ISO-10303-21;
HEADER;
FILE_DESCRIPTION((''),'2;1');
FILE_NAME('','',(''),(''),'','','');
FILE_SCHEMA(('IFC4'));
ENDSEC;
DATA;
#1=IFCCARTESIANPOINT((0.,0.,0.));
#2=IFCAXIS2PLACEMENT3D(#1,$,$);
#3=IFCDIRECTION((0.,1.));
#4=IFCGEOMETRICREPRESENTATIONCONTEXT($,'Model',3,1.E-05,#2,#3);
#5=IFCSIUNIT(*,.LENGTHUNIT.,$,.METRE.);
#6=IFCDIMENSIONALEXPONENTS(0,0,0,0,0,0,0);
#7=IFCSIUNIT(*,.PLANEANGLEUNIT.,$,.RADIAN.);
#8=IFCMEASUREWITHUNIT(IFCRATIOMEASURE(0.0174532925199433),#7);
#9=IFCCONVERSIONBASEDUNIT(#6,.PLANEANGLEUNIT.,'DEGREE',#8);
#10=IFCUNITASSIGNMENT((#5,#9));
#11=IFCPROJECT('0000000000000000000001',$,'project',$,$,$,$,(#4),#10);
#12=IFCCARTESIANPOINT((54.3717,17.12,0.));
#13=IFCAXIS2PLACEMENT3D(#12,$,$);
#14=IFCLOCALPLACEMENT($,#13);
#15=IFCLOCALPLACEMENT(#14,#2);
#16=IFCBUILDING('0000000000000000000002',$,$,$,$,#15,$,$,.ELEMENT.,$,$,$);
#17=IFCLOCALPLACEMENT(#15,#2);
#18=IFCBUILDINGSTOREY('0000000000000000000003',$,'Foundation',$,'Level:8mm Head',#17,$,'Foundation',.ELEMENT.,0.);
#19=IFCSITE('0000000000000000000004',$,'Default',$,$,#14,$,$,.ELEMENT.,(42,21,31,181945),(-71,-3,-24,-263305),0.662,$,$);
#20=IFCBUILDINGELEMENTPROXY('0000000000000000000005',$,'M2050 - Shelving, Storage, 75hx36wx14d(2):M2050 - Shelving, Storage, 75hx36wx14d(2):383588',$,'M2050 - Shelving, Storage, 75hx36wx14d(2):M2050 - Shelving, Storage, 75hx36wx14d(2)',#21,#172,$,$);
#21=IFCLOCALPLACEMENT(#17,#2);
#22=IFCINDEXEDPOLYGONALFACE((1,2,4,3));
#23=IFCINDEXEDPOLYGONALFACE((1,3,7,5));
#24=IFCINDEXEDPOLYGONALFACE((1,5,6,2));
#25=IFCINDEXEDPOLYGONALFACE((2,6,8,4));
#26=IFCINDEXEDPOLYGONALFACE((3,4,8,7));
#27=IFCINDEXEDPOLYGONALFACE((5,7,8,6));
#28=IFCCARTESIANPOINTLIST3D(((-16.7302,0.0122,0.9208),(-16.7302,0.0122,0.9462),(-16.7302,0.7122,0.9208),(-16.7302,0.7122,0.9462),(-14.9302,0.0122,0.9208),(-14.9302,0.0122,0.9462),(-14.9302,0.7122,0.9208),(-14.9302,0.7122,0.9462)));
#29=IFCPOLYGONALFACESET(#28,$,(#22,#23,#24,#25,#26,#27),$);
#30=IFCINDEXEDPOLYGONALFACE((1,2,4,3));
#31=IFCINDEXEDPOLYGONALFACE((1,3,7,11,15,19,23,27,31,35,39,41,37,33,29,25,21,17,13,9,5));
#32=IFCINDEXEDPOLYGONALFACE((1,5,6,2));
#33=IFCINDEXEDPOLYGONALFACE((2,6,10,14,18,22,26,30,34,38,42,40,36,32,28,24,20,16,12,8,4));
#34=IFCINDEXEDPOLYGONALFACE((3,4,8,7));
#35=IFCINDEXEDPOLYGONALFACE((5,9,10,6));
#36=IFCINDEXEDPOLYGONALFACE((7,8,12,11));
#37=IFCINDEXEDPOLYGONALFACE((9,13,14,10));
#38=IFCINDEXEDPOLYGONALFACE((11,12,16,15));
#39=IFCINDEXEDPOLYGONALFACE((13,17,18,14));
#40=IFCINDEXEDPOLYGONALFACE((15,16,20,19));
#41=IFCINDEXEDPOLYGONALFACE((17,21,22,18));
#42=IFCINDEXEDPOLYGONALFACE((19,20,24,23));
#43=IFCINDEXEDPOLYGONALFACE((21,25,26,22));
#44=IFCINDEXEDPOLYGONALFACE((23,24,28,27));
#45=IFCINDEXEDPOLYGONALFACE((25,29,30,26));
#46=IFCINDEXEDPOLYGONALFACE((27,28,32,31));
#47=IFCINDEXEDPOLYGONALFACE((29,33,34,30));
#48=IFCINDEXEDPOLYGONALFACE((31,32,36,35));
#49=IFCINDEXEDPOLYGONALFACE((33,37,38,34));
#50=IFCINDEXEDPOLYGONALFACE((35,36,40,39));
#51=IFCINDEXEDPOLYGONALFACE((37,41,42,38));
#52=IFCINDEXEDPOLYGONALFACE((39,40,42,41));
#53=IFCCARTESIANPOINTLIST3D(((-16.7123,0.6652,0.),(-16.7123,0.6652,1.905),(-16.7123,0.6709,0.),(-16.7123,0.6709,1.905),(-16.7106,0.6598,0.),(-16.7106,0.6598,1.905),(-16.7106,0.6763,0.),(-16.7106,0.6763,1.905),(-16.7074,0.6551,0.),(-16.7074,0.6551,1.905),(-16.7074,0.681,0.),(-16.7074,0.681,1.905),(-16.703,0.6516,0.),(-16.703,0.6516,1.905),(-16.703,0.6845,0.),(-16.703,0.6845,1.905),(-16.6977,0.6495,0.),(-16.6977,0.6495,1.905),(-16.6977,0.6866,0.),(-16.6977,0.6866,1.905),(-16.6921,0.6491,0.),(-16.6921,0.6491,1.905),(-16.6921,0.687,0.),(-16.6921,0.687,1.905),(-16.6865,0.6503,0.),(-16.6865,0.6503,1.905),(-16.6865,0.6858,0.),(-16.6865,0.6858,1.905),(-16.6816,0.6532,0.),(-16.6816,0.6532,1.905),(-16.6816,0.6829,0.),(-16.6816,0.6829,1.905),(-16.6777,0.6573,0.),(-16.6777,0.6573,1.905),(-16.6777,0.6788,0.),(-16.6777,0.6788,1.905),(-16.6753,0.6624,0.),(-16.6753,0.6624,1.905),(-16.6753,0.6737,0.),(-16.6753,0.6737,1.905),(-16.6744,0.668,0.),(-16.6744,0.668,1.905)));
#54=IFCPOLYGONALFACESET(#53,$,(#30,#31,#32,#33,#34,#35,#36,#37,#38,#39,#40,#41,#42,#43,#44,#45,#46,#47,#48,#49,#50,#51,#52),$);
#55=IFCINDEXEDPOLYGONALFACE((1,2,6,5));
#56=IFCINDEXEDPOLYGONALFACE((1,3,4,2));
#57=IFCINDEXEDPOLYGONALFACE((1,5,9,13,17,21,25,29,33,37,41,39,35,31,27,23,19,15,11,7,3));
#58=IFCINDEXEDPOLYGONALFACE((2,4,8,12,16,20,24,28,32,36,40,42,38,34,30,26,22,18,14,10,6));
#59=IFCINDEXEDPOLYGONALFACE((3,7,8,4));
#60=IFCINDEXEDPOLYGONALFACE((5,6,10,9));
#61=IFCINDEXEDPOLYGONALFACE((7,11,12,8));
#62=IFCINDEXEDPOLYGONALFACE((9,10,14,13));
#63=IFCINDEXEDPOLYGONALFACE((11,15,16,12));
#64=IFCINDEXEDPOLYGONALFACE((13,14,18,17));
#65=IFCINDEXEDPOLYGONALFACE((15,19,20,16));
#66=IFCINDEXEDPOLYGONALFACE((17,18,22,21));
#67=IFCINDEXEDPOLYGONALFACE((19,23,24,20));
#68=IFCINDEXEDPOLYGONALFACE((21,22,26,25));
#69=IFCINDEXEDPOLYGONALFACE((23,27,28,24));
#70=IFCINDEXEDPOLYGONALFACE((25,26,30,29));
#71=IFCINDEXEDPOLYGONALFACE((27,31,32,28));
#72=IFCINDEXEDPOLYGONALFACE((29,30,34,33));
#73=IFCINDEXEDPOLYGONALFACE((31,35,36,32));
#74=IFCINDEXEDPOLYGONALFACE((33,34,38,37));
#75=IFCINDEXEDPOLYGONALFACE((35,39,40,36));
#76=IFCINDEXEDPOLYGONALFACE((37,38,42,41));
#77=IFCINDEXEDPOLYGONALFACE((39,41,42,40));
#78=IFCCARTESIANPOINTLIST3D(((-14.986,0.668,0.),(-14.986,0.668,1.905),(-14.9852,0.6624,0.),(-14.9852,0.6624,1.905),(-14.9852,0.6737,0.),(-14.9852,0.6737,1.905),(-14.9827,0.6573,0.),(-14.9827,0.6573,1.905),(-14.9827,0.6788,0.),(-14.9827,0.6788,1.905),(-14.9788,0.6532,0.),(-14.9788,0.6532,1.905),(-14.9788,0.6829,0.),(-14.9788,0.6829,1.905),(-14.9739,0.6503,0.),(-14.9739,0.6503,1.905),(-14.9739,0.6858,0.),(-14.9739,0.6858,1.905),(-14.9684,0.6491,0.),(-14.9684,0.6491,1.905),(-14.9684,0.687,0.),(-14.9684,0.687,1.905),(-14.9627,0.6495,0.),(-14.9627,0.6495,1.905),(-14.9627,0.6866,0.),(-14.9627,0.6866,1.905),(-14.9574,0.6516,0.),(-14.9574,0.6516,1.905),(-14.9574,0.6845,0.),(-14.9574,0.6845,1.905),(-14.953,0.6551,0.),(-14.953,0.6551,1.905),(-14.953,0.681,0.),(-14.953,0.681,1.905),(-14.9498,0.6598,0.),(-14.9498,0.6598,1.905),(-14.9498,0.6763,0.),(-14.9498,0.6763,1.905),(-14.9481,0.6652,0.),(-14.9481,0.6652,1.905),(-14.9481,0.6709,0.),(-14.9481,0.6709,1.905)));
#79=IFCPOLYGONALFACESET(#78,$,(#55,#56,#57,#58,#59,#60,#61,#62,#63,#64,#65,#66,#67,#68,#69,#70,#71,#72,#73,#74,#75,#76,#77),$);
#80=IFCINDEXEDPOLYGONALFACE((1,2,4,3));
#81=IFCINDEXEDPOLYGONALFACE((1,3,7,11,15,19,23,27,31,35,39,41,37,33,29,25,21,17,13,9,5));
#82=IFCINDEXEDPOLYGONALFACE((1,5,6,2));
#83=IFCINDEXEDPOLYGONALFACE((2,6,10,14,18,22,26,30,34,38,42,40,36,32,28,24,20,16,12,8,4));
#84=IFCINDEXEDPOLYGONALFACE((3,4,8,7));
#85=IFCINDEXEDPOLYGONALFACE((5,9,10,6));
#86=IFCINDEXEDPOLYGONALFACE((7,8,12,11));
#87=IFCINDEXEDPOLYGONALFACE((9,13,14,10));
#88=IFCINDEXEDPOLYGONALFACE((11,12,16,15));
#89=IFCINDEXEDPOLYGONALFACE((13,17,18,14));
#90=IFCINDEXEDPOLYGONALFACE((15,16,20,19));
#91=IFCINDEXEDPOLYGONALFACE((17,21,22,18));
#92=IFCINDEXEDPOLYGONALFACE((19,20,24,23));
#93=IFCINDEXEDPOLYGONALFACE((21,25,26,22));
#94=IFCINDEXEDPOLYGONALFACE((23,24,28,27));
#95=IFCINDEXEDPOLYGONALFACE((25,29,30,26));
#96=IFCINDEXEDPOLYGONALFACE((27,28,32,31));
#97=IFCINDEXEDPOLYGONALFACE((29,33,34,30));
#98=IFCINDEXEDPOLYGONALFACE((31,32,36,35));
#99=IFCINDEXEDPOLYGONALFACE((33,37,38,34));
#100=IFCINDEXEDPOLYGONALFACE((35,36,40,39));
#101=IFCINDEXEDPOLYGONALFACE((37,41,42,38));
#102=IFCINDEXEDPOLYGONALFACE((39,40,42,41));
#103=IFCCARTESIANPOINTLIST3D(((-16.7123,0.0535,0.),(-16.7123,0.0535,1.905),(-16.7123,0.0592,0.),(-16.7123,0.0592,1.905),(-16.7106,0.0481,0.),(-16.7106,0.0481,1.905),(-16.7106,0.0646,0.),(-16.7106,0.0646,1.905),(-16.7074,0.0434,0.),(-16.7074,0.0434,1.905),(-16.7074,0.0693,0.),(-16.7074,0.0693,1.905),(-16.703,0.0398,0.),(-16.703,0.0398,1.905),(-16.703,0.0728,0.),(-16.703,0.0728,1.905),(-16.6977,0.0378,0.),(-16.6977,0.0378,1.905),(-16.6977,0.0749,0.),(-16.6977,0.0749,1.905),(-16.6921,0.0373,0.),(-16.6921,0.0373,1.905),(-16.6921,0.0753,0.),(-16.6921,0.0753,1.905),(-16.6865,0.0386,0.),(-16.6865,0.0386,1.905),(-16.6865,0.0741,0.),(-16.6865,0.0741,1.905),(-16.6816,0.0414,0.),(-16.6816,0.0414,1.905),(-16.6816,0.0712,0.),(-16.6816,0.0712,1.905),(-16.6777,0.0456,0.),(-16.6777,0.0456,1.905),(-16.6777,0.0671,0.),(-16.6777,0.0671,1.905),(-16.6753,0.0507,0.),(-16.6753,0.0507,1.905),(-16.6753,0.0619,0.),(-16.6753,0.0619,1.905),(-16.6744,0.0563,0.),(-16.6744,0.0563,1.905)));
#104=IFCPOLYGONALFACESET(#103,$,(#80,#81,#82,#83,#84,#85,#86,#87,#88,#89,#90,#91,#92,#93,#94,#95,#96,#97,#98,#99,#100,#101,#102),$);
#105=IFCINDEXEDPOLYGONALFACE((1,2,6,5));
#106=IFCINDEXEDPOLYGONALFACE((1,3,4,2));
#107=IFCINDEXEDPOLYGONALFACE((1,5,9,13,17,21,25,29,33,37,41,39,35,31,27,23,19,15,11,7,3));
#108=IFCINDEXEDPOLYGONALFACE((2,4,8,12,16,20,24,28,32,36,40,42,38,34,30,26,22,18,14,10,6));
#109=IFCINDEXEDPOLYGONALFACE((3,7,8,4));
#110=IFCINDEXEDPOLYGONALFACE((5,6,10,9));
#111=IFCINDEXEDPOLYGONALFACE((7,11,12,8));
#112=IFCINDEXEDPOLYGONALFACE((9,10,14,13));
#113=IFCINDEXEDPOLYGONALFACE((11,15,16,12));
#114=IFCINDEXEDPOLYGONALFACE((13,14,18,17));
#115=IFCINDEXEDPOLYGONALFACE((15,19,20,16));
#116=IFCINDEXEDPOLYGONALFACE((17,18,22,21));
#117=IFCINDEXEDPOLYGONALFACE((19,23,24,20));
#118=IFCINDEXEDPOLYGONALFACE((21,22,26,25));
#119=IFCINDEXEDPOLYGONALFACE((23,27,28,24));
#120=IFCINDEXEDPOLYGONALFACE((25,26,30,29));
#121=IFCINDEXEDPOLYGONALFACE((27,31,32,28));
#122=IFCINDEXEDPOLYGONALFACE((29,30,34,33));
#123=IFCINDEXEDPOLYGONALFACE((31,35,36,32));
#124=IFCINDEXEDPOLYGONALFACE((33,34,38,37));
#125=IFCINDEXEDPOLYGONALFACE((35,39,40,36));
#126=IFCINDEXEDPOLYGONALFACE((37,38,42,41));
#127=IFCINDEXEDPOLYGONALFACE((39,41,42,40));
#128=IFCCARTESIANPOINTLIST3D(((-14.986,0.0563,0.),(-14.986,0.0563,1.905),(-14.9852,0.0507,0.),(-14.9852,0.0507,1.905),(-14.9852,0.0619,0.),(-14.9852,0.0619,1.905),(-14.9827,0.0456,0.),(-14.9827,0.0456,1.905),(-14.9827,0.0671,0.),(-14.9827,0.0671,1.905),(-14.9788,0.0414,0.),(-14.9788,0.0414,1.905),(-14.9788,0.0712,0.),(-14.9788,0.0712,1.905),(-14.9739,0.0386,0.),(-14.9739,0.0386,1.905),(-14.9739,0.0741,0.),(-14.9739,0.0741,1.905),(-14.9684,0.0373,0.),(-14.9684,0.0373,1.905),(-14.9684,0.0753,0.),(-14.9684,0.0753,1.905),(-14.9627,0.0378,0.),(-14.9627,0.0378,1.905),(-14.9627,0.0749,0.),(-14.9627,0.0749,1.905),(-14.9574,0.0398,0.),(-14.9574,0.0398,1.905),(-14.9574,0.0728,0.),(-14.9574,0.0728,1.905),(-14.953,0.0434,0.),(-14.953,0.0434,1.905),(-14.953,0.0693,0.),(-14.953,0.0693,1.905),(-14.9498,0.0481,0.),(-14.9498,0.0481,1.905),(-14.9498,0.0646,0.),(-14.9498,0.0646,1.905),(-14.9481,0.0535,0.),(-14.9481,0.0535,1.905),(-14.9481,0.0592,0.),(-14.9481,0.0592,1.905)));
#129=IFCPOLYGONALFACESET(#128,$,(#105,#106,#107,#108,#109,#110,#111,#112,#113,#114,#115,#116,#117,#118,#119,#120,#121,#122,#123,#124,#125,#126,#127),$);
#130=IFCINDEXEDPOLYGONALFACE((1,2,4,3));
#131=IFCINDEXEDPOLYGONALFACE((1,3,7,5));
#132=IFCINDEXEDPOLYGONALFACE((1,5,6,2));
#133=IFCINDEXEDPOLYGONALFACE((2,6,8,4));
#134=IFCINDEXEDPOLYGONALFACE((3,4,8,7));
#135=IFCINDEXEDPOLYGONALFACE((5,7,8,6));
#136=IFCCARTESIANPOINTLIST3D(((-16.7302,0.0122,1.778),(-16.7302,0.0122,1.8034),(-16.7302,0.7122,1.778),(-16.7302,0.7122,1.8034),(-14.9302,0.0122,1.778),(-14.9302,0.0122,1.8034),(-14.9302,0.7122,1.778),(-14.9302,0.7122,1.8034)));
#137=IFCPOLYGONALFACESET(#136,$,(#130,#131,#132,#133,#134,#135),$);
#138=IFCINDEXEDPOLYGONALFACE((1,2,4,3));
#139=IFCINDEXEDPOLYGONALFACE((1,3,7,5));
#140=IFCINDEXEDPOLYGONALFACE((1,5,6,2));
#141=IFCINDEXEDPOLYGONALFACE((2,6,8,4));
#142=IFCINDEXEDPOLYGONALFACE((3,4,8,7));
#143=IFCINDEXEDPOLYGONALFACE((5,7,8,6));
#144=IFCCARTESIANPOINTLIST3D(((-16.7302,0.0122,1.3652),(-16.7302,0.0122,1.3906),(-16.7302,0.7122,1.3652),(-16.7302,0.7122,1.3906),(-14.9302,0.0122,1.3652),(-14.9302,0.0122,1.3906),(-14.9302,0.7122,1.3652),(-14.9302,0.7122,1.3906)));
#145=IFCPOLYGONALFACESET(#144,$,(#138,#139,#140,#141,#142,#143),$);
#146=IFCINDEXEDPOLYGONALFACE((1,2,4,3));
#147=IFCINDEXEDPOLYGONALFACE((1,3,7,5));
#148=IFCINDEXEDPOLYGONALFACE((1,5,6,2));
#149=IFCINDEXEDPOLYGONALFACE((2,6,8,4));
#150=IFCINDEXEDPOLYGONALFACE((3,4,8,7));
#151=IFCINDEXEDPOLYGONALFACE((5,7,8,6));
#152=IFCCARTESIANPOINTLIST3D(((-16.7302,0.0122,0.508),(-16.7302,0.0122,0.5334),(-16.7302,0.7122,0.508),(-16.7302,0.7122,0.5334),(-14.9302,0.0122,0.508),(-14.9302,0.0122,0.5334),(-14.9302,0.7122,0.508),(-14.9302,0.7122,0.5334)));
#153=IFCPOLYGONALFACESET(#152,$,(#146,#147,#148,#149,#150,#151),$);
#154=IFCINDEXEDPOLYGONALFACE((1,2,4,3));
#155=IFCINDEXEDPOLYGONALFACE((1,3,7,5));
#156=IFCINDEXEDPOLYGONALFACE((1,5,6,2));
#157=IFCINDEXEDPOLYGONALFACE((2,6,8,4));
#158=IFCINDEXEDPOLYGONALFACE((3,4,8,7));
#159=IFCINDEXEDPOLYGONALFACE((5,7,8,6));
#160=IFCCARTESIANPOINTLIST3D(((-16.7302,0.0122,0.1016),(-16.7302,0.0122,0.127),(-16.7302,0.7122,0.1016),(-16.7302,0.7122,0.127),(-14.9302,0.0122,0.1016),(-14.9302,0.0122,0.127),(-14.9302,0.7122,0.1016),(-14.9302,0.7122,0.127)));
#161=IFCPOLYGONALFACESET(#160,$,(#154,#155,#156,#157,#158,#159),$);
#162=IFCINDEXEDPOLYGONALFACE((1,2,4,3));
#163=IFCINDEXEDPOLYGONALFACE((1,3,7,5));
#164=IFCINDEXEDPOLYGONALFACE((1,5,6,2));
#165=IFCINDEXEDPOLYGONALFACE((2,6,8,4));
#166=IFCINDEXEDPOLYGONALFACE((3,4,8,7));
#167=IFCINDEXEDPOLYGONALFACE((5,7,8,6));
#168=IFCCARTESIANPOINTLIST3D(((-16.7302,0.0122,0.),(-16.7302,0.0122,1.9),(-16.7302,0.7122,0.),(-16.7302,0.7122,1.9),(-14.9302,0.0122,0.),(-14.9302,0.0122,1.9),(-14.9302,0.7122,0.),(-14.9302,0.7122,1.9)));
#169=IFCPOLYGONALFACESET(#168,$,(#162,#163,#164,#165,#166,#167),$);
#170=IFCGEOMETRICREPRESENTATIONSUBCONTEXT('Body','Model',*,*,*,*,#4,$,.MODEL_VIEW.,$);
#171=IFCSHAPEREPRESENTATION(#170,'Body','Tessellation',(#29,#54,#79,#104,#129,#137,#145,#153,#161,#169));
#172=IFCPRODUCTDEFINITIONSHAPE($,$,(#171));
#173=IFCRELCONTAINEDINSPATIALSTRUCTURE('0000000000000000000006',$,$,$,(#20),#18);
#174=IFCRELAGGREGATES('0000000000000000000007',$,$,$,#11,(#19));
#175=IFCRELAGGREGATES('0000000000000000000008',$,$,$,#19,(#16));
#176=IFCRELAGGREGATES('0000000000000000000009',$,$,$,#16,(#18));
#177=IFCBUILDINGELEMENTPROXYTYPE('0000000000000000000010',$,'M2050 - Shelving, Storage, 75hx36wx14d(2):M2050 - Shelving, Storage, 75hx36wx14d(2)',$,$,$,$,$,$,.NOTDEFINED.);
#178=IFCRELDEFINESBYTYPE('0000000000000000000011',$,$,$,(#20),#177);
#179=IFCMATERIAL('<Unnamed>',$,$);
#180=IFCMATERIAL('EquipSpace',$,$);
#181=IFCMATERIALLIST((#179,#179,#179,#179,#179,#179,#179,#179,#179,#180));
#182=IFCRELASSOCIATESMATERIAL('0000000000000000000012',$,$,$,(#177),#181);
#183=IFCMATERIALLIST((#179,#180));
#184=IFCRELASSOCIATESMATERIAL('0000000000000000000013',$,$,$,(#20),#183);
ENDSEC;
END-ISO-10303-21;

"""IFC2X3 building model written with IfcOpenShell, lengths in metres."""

from ifc_helpers import new_model, entity, si_unit, converted_unit, direction, frame, frame_2d, origin, origin_2d_with_axis, place, context, subcontext, project, spatial, rectangle, circle, extrude, source, transform, mapped, material, material_list, type_object, type_shapes, element, save


model = new_model("IFC2X3")

# Units and contexts
model_context = context("Model", 3, precision=1e-05, world=origin(), true_north=direction((0.0, 1.0)))
body_context = subcontext(model_context, "Body", "Model", "MODEL_VIEW")
ifc_project = project(units=[si_unit("LENGTHUNIT", "METRE"), converted_unit("PLANEANGLEUNIT", "DEGREE", entity("IfcRatioMeasure", 0.0174532925199433), si_unit("PLANEANGLEUNIT", "RADIAN"), dimensions=[0, 0, 0, 0, 0, 0, 0])], contexts=[model_context])

# Site, building, storey
site_placement = place(None, frame((54.3717, 17.12, 0.0)))
site = spatial("IfcSite", under=ifc_project, at=site_placement, Name="Default", CompositionType="ELEMENT", RefLatitude=(42, 21, 31, 181945), RefLongitude=(-71, -3, -24, -263305), RefElevation=0.662)
building_placement = place(site_placement, origin())
building = spatial("IfcBuilding", under=site, at=building_placement, CompositionType="ELEMENT")
storey_placement = place(building_placement, origin())
storey = spatial("IfcBuildingStorey", under=building, at=storey_placement, Name="Foundation", ObjectType="Level:8mm Head", LongName="Foundation", CompositionType="ELEMENT", Elevation=0.0)

# Building element proxy
ifc_material_1 = material(Name="<Unnamed>")
ifc_material_2 = material(Name="EquipSpace")
ifc_material_list_1 = material_list([ifc_material_1, ifc_material_1, ifc_material_1, ifc_material_1, ifc_material_1, ifc_material_1, ifc_material_1, ifc_material_1, ifc_material_1, ifc_material_2])
building_element_proxy_type = type_object("IfcBuildingElementProxyType", Name="M2050 - Shelving, Storage, 75hx36wx14d(2):M2050 - Shelving, Storage, 75hx36wx14d(2)", PredefinedType="NOTDEFINED", material=ifc_material_list_1)
shared_shape = source(origin(), body_context, "Body", "SweptSolid", [
    extrude(rectangle(XDim=1.8, YDim=0.7, at=origin_2d_with_axis()), frame((0.0, 0.0, 0.9207), z_axis=(0.0, 0.0, 1.0), x_axis=(-1.0, 0.0, 0.0)), (0.0, 0.0, 1.0), 0.0254),
    extrude(circle(Radius=0.0191, at=origin_2d_with_axis()), frame((0.8633, -0.3059, 0.0), z_axis=(0.0, 0.0, 1.0), x_axis=(-1.0, 0.0, 0.0)), (0.0, 0.0, 1.0), 1.905),
    extrude(circle(Radius=0.0191, at=origin_2d_with_axis()), frame((-0.8633, -0.3059, 0.0)), (0.0, 0.0, 1.0), 1.905),
    extrude(circle(Radius=0.0191, at=origin_2d_with_axis()), frame((0.8633, 0.3059, 0.0), z_axis=(0.0, 0.0, 1.0), x_axis=(-1.0, 0.0, 0.0)), (0.0, 0.0, 1.0), 1.905),
    extrude(circle(Radius=0.0191, at=origin_2d_with_axis()), frame((-0.8633, 0.3059, 0.0)), (0.0, 0.0, 1.0), 1.905),
    extrude(rectangle(XDim=1.8, YDim=0.7, at=origin_2d_with_axis()), frame((0.0, 0.0, 1.778), z_axis=(0.0, 0.0, 1.0), x_axis=(-1.0, 0.0, 0.0)), (0.0, 0.0, 1.0), 0.0254),
    extrude(rectangle(XDim=1.8, YDim=0.7, at=origin_2d_with_axis()), frame((0.0, 0.0, 1.3653), z_axis=(0.0, 0.0, 1.0), x_axis=(-1.0, 0.0, 0.0)), (0.0, 0.0, 1.0), 0.0254),
    extrude(rectangle(XDim=1.8, YDim=0.7, at=origin_2d_with_axis()), frame((0.0, 0.0, 0.508), z_axis=(0.0, 0.0, 1.0), x_axis=(-1.0, 0.0, 0.0)), (0.0, 0.0, 1.0), 0.0254),
    extrude(rectangle(XDim=1.8, YDim=0.7, at=origin_2d_with_axis()), frame((0.0, 0.0, 0.1016), z_axis=(0.0, 0.0, 1.0), x_axis=(-1.0, 0.0, 0.0)), (0.0, 0.0, 1.0), 0.0254),
    extrude(rectangle(XDim=0.7, YDim=1.8, at=frame_2d((0.0, 0.18), x_axis=(1.0, 0.0))), frame((-0.18, 0.0, 0.0), z_axis=(0.0, 0.0, 1.0), x_axis=(0.0, -1.0, 0.0)), (0.0, 0.0, 1.0), 1.9),
])
type_shapes(building_element_proxy_type, [shared_shape])
ifc_material_list_2 = material_list([ifc_material_1, ifc_material_2])
proxy_1_placement = place(storey_placement, frame((-15.8302, 0.3622, 0.0), z_axis=(0.0, 0.0, 1.0), x_axis=(-1.0, 0.0, 0.0)))
element("IfcBuildingElementProxy", 1, at=proxy_1_placement, inside=storey, type_object=building_element_proxy_type, material=ifc_material_list_2, Name="M2050 - Shelving, Storage, 75hx36wx14d(2):M2050 - Shelving, Storage, 75hx36wx14d(2):383588", ObjectType="M2050 - Shelving, Storage, 75hx36wx14d(2):M2050 - Shelving, Storage, 75hx36wx14d(2)", context=body_context, shape_type="MappedRepresentation", body=[
    mapped(shared_shape, transform((0.0, 0.0, 0.0), scale=1.0)),
])

save(model, "model.ifc")
